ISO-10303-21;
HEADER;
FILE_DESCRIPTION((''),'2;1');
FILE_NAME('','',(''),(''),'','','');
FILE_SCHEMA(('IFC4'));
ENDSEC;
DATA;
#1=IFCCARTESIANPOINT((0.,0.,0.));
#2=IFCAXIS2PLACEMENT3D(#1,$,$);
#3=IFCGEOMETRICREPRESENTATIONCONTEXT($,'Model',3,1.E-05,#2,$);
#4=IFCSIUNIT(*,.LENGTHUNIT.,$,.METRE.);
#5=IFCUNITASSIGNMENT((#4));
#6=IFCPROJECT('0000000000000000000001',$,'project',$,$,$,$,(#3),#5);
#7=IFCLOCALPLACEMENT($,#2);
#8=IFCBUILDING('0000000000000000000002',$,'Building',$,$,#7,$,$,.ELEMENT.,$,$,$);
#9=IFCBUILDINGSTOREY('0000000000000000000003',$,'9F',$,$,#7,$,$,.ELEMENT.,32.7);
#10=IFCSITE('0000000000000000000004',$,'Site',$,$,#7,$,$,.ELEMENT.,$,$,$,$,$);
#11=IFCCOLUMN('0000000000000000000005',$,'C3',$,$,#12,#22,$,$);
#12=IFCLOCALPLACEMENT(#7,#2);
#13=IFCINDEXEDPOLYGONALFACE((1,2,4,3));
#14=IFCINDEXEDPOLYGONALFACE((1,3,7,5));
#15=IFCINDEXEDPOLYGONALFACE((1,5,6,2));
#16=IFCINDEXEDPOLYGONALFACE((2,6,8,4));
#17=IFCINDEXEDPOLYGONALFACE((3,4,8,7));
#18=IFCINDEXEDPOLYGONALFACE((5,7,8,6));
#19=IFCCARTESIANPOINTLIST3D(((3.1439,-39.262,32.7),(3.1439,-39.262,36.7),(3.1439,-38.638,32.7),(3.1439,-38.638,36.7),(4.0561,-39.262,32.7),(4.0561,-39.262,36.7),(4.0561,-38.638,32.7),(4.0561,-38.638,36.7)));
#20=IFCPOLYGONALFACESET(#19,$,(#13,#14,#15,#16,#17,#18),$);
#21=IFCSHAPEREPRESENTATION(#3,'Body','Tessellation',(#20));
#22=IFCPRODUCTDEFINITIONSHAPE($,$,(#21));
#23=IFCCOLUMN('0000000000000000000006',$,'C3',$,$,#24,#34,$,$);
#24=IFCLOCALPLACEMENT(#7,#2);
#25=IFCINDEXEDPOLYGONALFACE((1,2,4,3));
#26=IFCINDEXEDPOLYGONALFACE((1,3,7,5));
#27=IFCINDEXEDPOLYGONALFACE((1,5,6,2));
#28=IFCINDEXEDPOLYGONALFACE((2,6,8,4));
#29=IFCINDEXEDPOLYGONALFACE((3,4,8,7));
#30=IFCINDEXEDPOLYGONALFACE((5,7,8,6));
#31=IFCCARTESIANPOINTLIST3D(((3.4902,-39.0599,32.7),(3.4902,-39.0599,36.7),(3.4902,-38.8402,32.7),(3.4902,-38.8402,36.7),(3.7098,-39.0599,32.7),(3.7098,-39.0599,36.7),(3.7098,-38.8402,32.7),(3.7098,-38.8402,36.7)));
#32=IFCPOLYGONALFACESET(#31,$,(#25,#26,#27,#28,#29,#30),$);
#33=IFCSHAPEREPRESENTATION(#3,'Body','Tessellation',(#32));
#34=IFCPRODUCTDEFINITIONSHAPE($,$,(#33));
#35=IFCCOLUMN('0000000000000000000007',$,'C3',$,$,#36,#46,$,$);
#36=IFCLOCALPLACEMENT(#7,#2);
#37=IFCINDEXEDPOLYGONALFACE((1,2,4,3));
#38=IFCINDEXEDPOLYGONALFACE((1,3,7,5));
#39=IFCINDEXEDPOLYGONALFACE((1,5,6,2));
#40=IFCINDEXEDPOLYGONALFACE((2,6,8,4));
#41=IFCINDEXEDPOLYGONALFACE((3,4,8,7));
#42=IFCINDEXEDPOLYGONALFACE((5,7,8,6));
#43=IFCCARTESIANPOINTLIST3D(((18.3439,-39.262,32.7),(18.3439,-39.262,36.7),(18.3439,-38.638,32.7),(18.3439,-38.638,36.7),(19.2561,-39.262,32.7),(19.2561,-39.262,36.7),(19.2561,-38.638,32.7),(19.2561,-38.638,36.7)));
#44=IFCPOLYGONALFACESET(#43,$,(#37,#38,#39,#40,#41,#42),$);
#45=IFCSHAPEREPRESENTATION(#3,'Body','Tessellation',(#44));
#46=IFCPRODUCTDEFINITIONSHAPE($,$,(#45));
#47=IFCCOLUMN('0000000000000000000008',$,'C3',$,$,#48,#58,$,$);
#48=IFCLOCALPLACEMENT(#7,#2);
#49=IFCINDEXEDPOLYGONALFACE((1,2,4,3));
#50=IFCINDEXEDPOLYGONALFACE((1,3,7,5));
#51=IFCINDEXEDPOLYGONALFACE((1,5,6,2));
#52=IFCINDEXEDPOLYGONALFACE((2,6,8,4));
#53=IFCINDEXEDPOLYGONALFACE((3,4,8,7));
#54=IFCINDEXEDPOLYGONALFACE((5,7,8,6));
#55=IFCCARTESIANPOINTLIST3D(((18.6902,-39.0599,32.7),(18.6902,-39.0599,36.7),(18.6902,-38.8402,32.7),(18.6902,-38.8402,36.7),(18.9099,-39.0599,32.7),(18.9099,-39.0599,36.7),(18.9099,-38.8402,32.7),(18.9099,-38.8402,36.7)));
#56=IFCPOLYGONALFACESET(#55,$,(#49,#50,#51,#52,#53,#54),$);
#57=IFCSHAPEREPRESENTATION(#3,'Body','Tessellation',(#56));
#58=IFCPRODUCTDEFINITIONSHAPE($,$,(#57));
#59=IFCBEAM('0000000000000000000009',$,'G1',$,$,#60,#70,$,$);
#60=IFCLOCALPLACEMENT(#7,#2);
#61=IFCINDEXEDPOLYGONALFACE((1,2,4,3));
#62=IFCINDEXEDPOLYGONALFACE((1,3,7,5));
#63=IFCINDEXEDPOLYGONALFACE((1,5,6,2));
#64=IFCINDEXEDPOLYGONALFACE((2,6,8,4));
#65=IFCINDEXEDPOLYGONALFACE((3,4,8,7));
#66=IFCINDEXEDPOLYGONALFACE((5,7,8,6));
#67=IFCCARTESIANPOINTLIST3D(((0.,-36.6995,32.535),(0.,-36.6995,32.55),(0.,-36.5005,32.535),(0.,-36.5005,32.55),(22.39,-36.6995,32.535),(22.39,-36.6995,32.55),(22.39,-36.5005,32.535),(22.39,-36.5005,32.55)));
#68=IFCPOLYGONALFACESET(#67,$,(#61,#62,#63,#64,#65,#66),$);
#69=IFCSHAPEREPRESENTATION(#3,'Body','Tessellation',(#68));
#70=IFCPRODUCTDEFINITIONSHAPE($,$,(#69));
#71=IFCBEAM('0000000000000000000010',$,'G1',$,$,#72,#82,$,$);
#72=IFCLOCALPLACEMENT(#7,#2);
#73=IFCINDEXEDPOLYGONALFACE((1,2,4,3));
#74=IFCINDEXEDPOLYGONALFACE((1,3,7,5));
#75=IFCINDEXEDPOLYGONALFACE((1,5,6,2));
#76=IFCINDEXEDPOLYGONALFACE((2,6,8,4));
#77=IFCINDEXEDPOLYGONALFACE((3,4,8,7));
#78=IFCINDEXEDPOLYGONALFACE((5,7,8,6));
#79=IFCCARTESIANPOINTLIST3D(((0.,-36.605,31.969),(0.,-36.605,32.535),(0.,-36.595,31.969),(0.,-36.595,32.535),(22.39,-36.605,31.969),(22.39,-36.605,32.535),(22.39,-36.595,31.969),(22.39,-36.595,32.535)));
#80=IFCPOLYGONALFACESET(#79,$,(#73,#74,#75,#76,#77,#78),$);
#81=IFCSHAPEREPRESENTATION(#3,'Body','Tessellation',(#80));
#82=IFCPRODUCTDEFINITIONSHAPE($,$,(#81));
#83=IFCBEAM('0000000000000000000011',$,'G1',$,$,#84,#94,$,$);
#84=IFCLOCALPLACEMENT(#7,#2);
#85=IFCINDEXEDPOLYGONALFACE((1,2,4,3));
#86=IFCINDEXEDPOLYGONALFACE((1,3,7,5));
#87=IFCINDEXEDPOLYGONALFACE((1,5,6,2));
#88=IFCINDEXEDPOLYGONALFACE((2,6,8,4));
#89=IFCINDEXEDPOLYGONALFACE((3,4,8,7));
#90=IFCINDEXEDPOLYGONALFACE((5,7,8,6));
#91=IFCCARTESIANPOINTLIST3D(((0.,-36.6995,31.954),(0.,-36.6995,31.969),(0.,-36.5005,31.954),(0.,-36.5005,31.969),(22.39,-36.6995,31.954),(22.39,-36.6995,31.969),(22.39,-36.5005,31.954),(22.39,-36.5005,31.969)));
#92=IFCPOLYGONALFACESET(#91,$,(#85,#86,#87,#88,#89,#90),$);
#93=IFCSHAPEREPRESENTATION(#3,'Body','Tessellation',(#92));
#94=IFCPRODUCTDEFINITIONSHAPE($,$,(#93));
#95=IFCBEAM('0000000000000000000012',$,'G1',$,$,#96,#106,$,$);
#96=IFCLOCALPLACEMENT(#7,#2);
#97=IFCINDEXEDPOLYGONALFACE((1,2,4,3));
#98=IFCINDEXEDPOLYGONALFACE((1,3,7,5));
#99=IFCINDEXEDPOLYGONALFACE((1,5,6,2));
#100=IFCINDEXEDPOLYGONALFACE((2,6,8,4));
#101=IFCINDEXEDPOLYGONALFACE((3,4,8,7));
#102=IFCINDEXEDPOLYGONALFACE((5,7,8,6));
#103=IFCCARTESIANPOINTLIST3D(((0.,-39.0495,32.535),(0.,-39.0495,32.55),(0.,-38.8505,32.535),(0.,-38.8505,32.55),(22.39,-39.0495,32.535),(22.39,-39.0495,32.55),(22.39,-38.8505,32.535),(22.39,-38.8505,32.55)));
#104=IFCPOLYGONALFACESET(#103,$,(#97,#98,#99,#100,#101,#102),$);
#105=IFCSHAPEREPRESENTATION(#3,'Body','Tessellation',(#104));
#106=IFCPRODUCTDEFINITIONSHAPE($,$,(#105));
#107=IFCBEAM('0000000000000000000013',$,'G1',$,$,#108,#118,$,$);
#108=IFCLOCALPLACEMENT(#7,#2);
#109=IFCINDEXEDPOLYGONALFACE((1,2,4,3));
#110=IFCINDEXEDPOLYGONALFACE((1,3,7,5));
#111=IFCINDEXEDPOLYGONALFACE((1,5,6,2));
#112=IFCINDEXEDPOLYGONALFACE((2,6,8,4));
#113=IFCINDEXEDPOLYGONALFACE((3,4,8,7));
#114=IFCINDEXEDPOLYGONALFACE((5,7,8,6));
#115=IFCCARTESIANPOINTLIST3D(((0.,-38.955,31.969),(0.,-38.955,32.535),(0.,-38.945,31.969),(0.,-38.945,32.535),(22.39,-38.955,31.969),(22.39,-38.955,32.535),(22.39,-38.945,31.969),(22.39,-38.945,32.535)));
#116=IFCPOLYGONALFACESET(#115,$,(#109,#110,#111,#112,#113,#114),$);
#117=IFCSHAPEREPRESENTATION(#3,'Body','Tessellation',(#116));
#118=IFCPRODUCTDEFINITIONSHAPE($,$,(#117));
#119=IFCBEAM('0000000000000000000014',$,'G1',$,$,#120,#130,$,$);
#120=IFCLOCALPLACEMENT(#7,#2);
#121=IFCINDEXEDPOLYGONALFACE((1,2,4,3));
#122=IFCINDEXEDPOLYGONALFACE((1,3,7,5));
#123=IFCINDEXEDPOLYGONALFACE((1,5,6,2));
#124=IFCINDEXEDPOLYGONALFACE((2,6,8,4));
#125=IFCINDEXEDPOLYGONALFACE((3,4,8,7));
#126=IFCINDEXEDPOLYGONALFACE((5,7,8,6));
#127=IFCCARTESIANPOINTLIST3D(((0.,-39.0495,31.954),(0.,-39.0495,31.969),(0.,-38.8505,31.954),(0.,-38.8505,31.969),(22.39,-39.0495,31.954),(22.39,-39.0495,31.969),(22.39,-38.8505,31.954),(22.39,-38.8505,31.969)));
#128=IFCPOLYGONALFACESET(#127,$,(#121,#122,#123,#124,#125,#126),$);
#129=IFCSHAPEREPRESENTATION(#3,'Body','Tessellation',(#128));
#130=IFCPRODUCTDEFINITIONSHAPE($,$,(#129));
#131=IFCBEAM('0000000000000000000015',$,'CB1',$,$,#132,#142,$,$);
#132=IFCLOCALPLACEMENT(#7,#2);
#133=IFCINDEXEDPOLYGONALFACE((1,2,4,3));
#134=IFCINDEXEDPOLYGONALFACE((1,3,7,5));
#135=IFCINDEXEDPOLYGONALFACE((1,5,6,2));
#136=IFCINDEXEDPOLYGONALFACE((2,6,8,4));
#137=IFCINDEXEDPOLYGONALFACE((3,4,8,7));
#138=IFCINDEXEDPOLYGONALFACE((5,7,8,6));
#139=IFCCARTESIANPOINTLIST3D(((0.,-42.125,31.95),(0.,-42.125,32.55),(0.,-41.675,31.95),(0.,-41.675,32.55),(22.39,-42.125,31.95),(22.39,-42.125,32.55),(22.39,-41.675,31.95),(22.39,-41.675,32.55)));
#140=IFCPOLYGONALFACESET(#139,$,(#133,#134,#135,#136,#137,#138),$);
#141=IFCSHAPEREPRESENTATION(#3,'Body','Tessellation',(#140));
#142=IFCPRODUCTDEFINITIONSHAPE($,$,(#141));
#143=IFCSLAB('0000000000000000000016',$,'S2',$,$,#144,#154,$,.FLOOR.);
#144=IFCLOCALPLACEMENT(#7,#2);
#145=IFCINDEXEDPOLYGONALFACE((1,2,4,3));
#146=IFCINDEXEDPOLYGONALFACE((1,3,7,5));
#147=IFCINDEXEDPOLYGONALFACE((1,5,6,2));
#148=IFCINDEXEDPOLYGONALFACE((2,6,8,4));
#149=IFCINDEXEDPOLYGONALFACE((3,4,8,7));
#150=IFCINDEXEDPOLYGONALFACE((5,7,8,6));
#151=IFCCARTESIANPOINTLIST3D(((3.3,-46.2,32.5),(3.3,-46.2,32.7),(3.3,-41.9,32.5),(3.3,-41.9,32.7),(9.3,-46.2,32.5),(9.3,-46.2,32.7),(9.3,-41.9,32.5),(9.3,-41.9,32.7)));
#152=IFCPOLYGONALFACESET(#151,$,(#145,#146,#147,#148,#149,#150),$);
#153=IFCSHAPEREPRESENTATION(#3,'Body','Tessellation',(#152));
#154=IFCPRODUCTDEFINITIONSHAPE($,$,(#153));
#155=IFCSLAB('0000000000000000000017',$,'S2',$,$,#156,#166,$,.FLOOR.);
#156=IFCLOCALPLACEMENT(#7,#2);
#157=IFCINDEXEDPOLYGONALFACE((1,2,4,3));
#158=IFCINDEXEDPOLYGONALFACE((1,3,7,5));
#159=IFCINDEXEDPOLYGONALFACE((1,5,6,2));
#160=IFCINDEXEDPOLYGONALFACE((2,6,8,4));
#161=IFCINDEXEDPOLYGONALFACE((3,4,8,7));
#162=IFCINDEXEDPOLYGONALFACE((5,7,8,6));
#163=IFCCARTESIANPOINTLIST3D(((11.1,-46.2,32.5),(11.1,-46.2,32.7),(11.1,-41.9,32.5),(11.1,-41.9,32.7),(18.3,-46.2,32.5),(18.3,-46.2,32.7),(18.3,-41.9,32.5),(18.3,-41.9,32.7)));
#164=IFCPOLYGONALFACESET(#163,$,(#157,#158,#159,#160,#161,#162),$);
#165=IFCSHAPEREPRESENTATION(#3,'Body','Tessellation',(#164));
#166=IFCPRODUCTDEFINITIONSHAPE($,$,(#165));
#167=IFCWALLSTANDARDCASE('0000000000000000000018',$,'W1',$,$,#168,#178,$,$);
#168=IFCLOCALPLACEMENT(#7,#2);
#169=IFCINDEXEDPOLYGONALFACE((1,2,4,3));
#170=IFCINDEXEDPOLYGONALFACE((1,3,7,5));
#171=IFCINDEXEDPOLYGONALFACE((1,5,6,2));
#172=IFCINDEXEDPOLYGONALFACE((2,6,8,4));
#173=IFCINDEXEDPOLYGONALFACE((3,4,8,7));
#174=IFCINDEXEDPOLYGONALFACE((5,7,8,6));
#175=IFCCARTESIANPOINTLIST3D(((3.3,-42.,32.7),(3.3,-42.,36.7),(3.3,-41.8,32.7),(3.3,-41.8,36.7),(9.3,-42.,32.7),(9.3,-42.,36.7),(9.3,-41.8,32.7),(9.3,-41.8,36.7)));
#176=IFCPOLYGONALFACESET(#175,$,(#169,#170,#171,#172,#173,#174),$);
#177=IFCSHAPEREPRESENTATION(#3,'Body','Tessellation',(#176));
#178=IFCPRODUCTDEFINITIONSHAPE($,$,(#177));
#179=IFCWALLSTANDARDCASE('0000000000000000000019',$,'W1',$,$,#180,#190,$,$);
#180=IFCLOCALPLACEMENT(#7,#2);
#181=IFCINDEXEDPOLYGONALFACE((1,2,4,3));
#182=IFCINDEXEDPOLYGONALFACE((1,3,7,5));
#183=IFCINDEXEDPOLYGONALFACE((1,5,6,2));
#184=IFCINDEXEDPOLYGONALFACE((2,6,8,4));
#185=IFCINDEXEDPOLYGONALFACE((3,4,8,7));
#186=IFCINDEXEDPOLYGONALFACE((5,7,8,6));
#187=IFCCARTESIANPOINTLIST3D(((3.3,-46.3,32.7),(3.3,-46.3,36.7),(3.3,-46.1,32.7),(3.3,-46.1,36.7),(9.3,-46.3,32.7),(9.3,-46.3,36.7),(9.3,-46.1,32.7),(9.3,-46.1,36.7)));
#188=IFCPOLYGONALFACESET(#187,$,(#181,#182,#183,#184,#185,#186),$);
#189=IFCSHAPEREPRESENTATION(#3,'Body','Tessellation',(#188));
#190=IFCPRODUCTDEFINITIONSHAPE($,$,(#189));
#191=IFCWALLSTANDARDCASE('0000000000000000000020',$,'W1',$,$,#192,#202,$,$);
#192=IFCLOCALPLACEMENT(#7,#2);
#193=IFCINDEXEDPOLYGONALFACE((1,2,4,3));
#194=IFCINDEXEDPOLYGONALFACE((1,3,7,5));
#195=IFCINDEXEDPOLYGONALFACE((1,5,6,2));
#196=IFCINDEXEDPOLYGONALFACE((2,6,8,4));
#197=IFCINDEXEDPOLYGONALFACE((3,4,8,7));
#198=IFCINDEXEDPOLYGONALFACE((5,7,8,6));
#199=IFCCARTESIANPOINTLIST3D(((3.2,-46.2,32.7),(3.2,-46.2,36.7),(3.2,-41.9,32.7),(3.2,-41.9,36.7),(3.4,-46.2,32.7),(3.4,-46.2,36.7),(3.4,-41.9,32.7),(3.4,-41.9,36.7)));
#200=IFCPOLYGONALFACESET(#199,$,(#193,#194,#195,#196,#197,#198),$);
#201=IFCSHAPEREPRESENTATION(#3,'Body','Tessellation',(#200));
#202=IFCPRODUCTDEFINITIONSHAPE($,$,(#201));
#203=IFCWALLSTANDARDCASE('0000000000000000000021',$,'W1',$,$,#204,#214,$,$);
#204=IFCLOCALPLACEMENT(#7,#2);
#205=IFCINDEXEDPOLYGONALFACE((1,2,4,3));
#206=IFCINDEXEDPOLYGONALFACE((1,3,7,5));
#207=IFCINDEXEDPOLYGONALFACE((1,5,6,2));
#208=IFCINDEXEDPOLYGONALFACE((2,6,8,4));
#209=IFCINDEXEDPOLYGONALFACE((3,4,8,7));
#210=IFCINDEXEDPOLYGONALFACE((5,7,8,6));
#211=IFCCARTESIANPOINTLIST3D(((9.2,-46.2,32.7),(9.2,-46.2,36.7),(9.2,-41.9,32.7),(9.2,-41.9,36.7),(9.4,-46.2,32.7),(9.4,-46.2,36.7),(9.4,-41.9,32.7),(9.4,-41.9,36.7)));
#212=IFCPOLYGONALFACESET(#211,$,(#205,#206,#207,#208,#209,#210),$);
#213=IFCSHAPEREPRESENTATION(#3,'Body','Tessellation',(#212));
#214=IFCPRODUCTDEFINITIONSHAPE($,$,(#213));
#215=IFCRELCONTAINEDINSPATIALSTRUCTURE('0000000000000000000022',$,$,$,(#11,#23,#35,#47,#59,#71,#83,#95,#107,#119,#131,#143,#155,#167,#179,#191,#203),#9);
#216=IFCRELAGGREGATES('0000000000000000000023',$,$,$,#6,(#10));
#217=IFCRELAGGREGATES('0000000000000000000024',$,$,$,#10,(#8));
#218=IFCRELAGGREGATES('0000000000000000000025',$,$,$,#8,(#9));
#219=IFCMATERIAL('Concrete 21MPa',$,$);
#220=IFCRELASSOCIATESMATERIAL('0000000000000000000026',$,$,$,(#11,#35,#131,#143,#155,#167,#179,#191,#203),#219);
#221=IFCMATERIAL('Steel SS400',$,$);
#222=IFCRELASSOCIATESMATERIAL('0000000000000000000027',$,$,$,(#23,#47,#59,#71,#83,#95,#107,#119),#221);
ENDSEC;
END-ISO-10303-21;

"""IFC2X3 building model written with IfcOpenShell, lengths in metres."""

from ifc_helpers import new_model, si_unit, frame, origin, origin_2d, place, context, project, spatial, rectangle, extrude, material, element, save


model = new_model("IFC2X3")

# Units and contexts
model_context = context("Model", 3, precision=1e-05, world=origin())
ifc_project = project(units=[si_unit("LENGTHUNIT", "METRE")], contexts=[model_context])

# Site, building, storey
placement = place(None, origin())
site = spatial("IfcSite", under=ifc_project, at=placement, Name="Site", CompositionType="ELEMENT")
building = spatial("IfcBuilding", under=site, at=placement, Name="Building", CompositionType="ELEMENT")
storey = spatial("IfcBuildingStorey", under=building, at=placement, Name="9F", CompositionType="ELEMENT", Elevation=32.7)

# Columns
ifc_material_1 = material(Name="Concrete 21MPa")
column_1_placement = place(None, frame((3.6, -38.95, 32.7)))
element("IfcColumn", 1, at=column_1_placement, inside=storey, material=ifc_material_1, Name="C3", context=model_context, shape_type="SweptSolid", body=[
    extrude(rectangle(XDim=0.9121, YDim=0.6241, at=origin_2d()), origin(), (0.0, 0.0, 1.0), 4.0),
])
ifc_material_2 = material(Name="Steel SS400")
column_2_placement = place(None, frame((3.6, -38.95, 32.7)))
element("IfcColumn", 2, at=column_2_placement, inside=storey, material=ifc_material_2, Name="C3", context=model_context, shape_type="SweptSolid", body=[
    extrude(rectangle(XDim=0.2197, YDim=0.2197, at=origin_2d()), origin(), (0.0, 0.0, 1.0), 4.0),
])
column_3_placement = place(None, frame((18.8, -38.95, 32.7)))
element("IfcColumn", 3, at=column_3_placement, inside=storey, material=ifc_material_1, Name="C3", context=model_context, shape_type="SweptSolid", body=[
    extrude(rectangle(XDim=0.9121, YDim=0.6241, at=origin_2d()), origin(), (0.0, 0.0, 1.0), 4.0),
])
column_4_placement = place(None, frame((18.8, -38.95, 32.7)))
element("IfcColumn", 4, at=column_4_placement, inside=storey, material=ifc_material_2, Name="C3", context=model_context, shape_type="SweptSolid", body=[
    extrude(rectangle(XDim=0.2197, YDim=0.2197, at=origin_2d()), origin(), (0.0, 0.0, 1.0), 4.0),
])

# Beams
beam_1_placement = place(None, frame((11.195, -36.6, 32.535)))
element("IfcBeam", 5, at=beam_1_placement, inside=storey, material=ifc_material_2, Name="G1", context=model_context, shape_type="SweptSolid", body=[
    extrude(rectangle(XDim=22.39, YDim=0.199, at=origin_2d()), origin(), (0.0, 0.0, 1.0), 0.015),
])
beam_2_placement = place(None, frame((11.195, -36.6, 31.969)))
element("IfcBeam", 6, at=beam_2_placement, inside=storey, material=ifc_material_2, Name="G1", context=model_context, shape_type="SweptSolid", body=[
    extrude(rectangle(XDim=22.39, YDim=0.01, at=origin_2d()), origin(), (0.0, 0.0, 1.0), 0.566),
])
for number, where, name in (
    (7, (11.195, -36.6, 31.954), "G1"),
    (8, (11.195, -38.95, 32.535), "G1"),
):
    element("IfcBeam", number, at=place(None, frame(where)), inside=storey, material=ifc_material_2, Name=name, context=model_context, shape_type="SweptSolid", body=[
        extrude(rectangle(XDim=22.39, YDim=0.199, at=origin_2d()), origin(), (0.0, 0.0, 1.0), 0.015),
    ])
beam_3_placement = place(None, frame((11.195, -38.95, 31.969)))
element("IfcBeam", 9, at=beam_3_placement, inside=storey, material=ifc_material_2, Name="G1", context=model_context, shape_type="SweptSolid", body=[
    extrude(rectangle(XDim=22.39, YDim=0.01, at=origin_2d()), origin(), (0.0, 0.0, 1.0), 0.566),
])
beam_4_placement = place(None, frame((11.195, -38.95, 31.954)))
element("IfcBeam", 10, at=beam_4_placement, inside=storey, material=ifc_material_2, Name="G1", context=model_context, shape_type="SweptSolid", body=[
    extrude(rectangle(XDim=22.39, YDim=0.199, at=origin_2d()), origin(), (0.0, 0.0, 1.0), 0.015),
])
beam_5_placement = place(None, frame((11.195, -41.9, 31.95)))
element("IfcBeam", 11, at=beam_5_placement, inside=storey, material=ifc_material_1, Name="CB1", context=model_context, shape_type="SweptSolid", body=[
    extrude(rectangle(XDim=22.39, YDim=0.45, at=origin_2d()), origin(), (0.0, 0.0, 1.0), 0.6),
])

# Slabs
slab_1_placement = place(None, frame((6.3, -44.05, 32.5)))
element("IfcSlab", 12, at=slab_1_placement, inside=storey, material=ifc_material_1, Name="S2", PredefinedType="FLOOR", context=model_context, shape_type="SweptSolid", body=[
    extrude(rectangle(XDim=6.0, YDim=4.3, at=origin_2d()), origin(), (0.0, 0.0, 1.0), 0.2),
])
slab_2_placement = place(None, frame((14.7, -44.05, 32.5)))
element("IfcSlab", 13, at=slab_2_placement, inside=storey, material=ifc_material_1, Name="S2", PredefinedType="FLOOR", context=model_context, shape_type="SweptSolid", body=[
    extrude(rectangle(XDim=7.2, YDim=4.3, at=origin_2d()), origin(), (0.0, 0.0, 1.0), 0.2),
])

# Walls
for number, where, name in (
    (14, (6.3, -41.9, 32.7), "W1"),
    (15, (6.3, -46.2, 32.7), "W1"),
):
    element("IfcWallStandardCase", number, at=place(None, frame(where)), inside=storey, material=ifc_material_1, Name=name, context=model_context, shape_type="SweptSolid", body=[
        extrude(rectangle(XDim=6.0, YDim=0.2, at=origin_2d()), origin(), (0.0, 0.0, 1.0), 4.0),
    ])
for number, where, name in (
    (16, (3.3, -44.05, 32.7), "W1"),
    (17, (9.3, -44.05, 32.7), "W1"),
):
    element("IfcWallStandardCase", number, at=place(None, frame(where)), inside=storey, material=ifc_material_1, Name=name, context=model_context, shape_type="SweptSolid", body=[
        extrude(rectangle(XDim=0.2, YDim=4.3, at=origin_2d()), origin(), (0.0, 0.0, 1.0), 4.0),
    ])

save(model, "model.ifc")
